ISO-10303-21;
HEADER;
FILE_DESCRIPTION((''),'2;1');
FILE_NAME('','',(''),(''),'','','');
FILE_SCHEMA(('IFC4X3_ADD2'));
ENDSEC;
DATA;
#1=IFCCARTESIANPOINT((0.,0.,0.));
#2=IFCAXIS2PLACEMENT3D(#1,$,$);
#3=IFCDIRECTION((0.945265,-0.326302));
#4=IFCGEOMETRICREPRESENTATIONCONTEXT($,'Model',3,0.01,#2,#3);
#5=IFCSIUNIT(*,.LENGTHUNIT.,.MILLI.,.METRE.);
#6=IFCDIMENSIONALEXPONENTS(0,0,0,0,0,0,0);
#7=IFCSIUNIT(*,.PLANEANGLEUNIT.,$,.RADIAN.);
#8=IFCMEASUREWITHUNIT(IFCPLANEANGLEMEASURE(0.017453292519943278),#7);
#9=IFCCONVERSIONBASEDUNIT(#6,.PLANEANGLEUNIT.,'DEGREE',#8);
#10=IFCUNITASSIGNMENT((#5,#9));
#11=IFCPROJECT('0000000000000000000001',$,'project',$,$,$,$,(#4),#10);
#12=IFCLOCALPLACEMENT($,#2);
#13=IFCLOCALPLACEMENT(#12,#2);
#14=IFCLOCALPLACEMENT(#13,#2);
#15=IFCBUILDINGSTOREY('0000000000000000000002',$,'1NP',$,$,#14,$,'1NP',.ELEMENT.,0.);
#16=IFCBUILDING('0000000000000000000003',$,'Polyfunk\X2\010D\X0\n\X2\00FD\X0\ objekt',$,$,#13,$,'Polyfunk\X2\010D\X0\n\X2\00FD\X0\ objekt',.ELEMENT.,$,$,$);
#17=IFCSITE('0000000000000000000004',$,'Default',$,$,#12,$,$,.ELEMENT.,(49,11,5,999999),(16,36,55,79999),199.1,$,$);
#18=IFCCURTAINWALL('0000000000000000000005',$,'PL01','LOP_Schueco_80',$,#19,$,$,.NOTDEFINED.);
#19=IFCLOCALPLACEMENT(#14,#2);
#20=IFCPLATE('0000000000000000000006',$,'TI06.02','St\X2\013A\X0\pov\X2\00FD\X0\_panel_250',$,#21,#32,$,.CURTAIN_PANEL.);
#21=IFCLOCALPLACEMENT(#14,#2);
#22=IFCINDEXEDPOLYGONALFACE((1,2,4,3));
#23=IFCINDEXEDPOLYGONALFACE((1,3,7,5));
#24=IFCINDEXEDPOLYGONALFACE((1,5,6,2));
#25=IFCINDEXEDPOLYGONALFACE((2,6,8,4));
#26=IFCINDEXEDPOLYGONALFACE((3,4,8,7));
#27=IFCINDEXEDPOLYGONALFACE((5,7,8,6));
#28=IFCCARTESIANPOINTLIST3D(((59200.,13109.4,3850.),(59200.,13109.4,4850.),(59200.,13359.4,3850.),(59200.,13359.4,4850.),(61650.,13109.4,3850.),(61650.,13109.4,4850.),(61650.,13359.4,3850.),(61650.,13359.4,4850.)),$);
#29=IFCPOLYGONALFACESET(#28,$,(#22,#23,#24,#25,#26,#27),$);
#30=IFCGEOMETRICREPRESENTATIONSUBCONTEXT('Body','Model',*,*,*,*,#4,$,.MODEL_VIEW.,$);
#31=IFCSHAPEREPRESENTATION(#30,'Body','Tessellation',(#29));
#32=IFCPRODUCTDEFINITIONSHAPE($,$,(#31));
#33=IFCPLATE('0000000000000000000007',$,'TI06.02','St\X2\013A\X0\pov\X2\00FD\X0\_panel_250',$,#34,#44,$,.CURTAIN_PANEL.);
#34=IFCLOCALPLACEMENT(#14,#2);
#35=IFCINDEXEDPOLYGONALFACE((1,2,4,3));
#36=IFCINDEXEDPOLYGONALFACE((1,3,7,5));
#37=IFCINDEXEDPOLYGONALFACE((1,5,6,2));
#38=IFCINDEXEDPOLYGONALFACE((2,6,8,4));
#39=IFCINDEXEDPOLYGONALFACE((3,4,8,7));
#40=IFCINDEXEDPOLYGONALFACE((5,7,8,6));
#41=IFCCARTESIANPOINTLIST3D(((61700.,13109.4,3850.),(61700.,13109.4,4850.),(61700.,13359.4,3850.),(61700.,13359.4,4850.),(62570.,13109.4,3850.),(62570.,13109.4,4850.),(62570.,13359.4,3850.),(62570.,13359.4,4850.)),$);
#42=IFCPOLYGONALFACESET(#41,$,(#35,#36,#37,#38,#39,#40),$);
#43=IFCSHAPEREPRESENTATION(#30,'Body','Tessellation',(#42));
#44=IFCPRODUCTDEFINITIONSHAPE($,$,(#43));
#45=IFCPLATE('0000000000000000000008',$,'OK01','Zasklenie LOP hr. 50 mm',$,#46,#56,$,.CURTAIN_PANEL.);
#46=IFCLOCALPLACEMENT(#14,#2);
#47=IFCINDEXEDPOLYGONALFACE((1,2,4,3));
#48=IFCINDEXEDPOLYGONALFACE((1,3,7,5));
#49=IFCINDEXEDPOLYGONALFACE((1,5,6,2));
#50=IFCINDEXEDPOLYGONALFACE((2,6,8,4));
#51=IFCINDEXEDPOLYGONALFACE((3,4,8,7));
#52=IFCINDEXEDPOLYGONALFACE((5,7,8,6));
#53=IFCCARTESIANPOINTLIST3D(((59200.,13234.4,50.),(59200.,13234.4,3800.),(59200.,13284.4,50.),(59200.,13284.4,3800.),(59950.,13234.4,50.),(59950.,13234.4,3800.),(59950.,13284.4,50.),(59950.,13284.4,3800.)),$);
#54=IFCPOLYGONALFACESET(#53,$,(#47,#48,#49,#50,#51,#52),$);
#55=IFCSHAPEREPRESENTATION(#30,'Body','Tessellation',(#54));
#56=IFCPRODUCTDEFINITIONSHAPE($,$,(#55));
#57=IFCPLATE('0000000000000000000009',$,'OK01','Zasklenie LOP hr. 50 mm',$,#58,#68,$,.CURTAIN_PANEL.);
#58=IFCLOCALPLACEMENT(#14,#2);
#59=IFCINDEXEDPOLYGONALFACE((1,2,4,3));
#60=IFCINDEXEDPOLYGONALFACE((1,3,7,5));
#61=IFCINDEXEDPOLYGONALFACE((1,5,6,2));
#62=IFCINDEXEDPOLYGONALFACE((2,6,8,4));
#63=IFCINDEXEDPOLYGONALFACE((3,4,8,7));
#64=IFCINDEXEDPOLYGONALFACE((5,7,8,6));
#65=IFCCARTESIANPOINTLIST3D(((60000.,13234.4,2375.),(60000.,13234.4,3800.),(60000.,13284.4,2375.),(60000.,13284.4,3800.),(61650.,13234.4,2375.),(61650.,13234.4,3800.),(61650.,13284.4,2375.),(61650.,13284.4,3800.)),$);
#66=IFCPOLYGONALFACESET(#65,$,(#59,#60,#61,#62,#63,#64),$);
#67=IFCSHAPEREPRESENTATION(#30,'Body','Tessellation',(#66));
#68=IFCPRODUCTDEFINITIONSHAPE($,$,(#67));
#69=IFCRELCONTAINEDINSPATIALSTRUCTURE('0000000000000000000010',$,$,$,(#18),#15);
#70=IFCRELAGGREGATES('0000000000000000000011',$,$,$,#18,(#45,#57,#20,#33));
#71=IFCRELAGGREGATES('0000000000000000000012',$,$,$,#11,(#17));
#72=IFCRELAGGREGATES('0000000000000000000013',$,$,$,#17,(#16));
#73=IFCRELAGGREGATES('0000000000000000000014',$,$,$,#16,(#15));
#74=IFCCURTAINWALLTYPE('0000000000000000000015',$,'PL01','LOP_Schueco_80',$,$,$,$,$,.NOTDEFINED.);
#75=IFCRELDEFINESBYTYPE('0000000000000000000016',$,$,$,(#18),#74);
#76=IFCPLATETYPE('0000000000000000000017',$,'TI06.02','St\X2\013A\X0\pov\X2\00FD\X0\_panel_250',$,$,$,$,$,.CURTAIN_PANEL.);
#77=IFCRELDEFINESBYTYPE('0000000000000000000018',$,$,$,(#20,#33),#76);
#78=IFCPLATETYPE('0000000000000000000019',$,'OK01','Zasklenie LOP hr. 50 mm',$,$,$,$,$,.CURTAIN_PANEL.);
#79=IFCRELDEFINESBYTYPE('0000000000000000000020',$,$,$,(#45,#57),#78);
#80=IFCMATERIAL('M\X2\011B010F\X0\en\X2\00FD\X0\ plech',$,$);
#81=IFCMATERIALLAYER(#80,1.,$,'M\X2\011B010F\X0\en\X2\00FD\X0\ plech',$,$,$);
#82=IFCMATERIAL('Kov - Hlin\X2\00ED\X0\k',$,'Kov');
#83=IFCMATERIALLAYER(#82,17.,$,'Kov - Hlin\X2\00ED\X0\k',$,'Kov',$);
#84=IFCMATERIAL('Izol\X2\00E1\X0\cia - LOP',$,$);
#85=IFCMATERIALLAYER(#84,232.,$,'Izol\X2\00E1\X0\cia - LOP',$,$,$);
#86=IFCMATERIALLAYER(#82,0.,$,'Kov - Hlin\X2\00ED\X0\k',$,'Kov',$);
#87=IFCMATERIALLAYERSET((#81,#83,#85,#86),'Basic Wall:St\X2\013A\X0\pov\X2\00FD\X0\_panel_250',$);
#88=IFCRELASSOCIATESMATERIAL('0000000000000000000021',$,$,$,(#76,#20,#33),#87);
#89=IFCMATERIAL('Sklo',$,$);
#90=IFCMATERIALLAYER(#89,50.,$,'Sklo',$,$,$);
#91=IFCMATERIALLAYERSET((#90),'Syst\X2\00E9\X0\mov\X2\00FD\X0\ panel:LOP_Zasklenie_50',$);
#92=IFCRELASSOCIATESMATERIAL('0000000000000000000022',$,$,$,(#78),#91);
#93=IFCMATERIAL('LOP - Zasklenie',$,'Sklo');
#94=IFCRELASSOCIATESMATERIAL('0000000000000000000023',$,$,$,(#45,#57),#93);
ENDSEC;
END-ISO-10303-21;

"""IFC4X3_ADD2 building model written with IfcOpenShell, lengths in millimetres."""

from ifc_helpers import new_model, entity, si_unit, converted_unit, direction, frame, frame_2d, origin, origin_2d_with_axis, place, context, subcontext, project, spatial, rectangle, extrude, source, transform, mapped, material, layer, layer_set, layer_usage, type_object, type_shapes, element, aggregate, save


model = new_model("IFC4X3_ADD2")

# Units and contexts
model_context = context("Model", 3, precision=0.01, world=origin(), true_north=direction((0.945265, -0.326302)))
body_context = subcontext(model_context, "Body", "Model", "MODEL_VIEW")
ifc_project = project(units=[si_unit("LENGTHUNIT", "METRE", prefix="MILLI"), converted_unit("PLANEANGLEUNIT", "DEGREE", entity("IfcPlaneAngleMeasure", 0.017453292519943278), si_unit("PLANEANGLEUNIT", "RADIAN"), dimensions=[0, 0, 0, 0, 0, 0, 0])], contexts=[model_context])

# Site, building, storey
site_placement = place(None, origin())
site = spatial("IfcSite", under=ifc_project, at=site_placement, Name="Default", CompositionType="ELEMENT", RefLatitude=(49, 11, 5, 999999), RefLongitude=(16, 36, 55, 79999), RefElevation=199.1)
building_placement = place(site_placement, origin())
building = spatial("IfcBuilding", under=site, at=building_placement, Name="Polyfunkčný objekt", LongName="Polyfunkčný objekt", CompositionType="ELEMENT")
storey_placement = place(building_placement, origin())
storey = spatial("IfcBuildingStorey", under=building, at=storey_placement, Name="1NP", LongName="1NP", CompositionType="ELEMENT", Elevation=0.0)

# Curtain wall, plates
curtain_wall_type = type_object("IfcCurtainWallType", Name="PL01", Description="LOP_Schueco_80", PredefinedType="NOTDEFINED")
curtain_wall_1_placement = place(storey_placement, origin())
curtain_wall_1 = element("IfcCurtainWall", 1, at=curtain_wall_1_placement, inside=storey, type_object=curtain_wall_type, Name="PL01", Description="LOP_Schueco_80", PredefinedType="NOTDEFINED")
ifc_material_1 = material(Name="Měďený plech")
ifc_layer_1 = layer(ifc_material_1, 1.0, Name="Měďený plech")
ifc_material_2 = material(Name="Kov - Hliník", Category="Kov")
ifc_layer_2 = layer(ifc_material_2, 17.0, Name="Kov - Hliník", Category="Kov")
ifc_material_3 = material(Name="Izolácia - LOP")
ifc_layer_3 = layer(ifc_material_3, 232.0, Name="Izolácia - LOP")
ifc_layer_4 = layer(ifc_material_2, 0.0, Name="Kov - Hliník", Category="Kov")
ifc_layer_set_1 = layer_set([ifc_layer_1, ifc_layer_2, ifc_layer_3, ifc_layer_4], Name="Basic Wall:Stĺpový_panel_250")
ifc_layer_usage_1 = layer_usage(ifc_layer_set_1, "AXIS2", "NEGATIVE", 125.0)
plate_type_1 = type_object("IfcPlateType", Name="TI06.02", Description="Stĺpový_panel_250", PredefinedType="CURTAIN_PANEL", material=ifc_layer_set_1)
plate_1_placement = place(storey_placement, frame((59200.0, 13234.4, 3850.0)))
plate_1 = element("IfcPlate", 2, at=plate_1_placement, type_object=plate_type_1, material=ifc_layer_usage_1, Name="TI06.02", Description="Stĺpový_panel_250", PredefinedType="CURTAIN_PANEL", context=body_context, shape_type="SweptSolid", body=[
    extrude(rectangle(XDim=250.0, YDim=2450.0, at=frame_2d((0.0, 0.0), x_axis=(1.0, 0.0))), frame((1225.0, 0.0, 0.0), z_axis=(0.0, 0.0, 1.0), x_axis=(0.0, 1.0, 0.0)), (0.0, 0.0, 1.0), 1000.0),
])
ifc_layer_usage_2 = layer_usage(ifc_layer_set_1, "AXIS2", "NEGATIVE", 125.0)
plate_2_placement = place(storey_placement, frame((61700.0, 13234.4, 3850.0)))
plate_2 = element("IfcPlate", 3, at=plate_2_placement, type_object=plate_type_1, material=ifc_layer_usage_2, Name="TI06.02", Description="Stĺpový_panel_250", PredefinedType="CURTAIN_PANEL", context=body_context, shape_type="SweptSolid", body=[
    extrude(rectangle(XDim=250.0, YDim=870.0, at=frame_2d((0.0, 0.0), x_axis=(1.0, 0.0))), frame((435.0, 0.0, 0.0), z_axis=(0.0, 0.0, 1.0), x_axis=(0.0, 1.0, 0.0)), (0.0, 0.0, 1.0), 1000.0),
])

# Plates
ifc_material_4 = material(Name="LOP - Zasklenie", Category="Sklo")
ifc_material_5 = material(Name="Sklo")
ifc_layer_5 = layer(ifc_material_5, 50.0, Name="Sklo")
ifc_layer_set_2 = layer_set([ifc_layer_5], Name="Systémový panel:LOP_Zasklenie_50")
plate_type_2 = type_object("IfcPlateType", Name="OK01", Description="Zasklenie LOP hr. 50 mm", PredefinedType="CURTAIN_PANEL", material=ifc_layer_set_2)
shared_shape_1 = source(origin(), body_context, "Body", "SweptSolid", [
    extrude(rectangle(XDim=3750.0, YDim=750.0, at=frame_2d((-141.7, 0.0), x_axis=(1.0, 0.0))), frame((0.0, 0.0, 2016.7), z_axis=(0.0, 1.0, 0.0), x_axis=(0.0, 0.0, 1.0)), (0.0, 0.0, 1.0), 50.0),
])
plate_3_placement = place(curtain_wall_1_placement, frame((59575.0, 13234.4, 50.0)))
plate_3 = element("IfcPlate", 4, at=plate_3_placement, type_object=plate_type_2, material=ifc_material_4, Name="OK01", Description="Zasklenie LOP hr. 50 mm", PredefinedType="CURTAIN_PANEL", context=body_context, shape_type="MappedRepresentation", body=[
    mapped(shared_shape_1, transform((0.0, 0.0, 0.0), scale=1.0)),
])
shared_shape_2 = source(origin(), body_context, "Body", "SweptSolid", [
    extrude(rectangle(XDim=50.0, YDim=1650.0, at=origin_2d_with_axis()), frame((0.0, 25.0, 0.0), z_axis=(0.0, 0.0, 1.0), x_axis=(0.0, 1.0, 0.0)), (0.0, 0.0, 1.0), 1425.0),
])
type_shapes(plate_type_2, [shared_shape_1, shared_shape_2])
plate_4_placement = place(curtain_wall_1_placement, frame((60825.0, 13234.4, 2375.0)))
plate_4 = element("IfcPlate", 5, at=plate_4_placement, type_object=plate_type_2, material=ifc_material_4, Name="OK01", Description="Zasklenie LOP hr. 50 mm", PredefinedType="CURTAIN_PANEL", context=body_context, shape_type="MappedRepresentation", body=[
    mapped(shared_shape_2, transform((0.0, 0.0, 0.0), scale=1.0)),
])
aggregate(curtain_wall_1, [plate_3, plate_4, plate_1, plate_2])

save(model, "model.ifc")
